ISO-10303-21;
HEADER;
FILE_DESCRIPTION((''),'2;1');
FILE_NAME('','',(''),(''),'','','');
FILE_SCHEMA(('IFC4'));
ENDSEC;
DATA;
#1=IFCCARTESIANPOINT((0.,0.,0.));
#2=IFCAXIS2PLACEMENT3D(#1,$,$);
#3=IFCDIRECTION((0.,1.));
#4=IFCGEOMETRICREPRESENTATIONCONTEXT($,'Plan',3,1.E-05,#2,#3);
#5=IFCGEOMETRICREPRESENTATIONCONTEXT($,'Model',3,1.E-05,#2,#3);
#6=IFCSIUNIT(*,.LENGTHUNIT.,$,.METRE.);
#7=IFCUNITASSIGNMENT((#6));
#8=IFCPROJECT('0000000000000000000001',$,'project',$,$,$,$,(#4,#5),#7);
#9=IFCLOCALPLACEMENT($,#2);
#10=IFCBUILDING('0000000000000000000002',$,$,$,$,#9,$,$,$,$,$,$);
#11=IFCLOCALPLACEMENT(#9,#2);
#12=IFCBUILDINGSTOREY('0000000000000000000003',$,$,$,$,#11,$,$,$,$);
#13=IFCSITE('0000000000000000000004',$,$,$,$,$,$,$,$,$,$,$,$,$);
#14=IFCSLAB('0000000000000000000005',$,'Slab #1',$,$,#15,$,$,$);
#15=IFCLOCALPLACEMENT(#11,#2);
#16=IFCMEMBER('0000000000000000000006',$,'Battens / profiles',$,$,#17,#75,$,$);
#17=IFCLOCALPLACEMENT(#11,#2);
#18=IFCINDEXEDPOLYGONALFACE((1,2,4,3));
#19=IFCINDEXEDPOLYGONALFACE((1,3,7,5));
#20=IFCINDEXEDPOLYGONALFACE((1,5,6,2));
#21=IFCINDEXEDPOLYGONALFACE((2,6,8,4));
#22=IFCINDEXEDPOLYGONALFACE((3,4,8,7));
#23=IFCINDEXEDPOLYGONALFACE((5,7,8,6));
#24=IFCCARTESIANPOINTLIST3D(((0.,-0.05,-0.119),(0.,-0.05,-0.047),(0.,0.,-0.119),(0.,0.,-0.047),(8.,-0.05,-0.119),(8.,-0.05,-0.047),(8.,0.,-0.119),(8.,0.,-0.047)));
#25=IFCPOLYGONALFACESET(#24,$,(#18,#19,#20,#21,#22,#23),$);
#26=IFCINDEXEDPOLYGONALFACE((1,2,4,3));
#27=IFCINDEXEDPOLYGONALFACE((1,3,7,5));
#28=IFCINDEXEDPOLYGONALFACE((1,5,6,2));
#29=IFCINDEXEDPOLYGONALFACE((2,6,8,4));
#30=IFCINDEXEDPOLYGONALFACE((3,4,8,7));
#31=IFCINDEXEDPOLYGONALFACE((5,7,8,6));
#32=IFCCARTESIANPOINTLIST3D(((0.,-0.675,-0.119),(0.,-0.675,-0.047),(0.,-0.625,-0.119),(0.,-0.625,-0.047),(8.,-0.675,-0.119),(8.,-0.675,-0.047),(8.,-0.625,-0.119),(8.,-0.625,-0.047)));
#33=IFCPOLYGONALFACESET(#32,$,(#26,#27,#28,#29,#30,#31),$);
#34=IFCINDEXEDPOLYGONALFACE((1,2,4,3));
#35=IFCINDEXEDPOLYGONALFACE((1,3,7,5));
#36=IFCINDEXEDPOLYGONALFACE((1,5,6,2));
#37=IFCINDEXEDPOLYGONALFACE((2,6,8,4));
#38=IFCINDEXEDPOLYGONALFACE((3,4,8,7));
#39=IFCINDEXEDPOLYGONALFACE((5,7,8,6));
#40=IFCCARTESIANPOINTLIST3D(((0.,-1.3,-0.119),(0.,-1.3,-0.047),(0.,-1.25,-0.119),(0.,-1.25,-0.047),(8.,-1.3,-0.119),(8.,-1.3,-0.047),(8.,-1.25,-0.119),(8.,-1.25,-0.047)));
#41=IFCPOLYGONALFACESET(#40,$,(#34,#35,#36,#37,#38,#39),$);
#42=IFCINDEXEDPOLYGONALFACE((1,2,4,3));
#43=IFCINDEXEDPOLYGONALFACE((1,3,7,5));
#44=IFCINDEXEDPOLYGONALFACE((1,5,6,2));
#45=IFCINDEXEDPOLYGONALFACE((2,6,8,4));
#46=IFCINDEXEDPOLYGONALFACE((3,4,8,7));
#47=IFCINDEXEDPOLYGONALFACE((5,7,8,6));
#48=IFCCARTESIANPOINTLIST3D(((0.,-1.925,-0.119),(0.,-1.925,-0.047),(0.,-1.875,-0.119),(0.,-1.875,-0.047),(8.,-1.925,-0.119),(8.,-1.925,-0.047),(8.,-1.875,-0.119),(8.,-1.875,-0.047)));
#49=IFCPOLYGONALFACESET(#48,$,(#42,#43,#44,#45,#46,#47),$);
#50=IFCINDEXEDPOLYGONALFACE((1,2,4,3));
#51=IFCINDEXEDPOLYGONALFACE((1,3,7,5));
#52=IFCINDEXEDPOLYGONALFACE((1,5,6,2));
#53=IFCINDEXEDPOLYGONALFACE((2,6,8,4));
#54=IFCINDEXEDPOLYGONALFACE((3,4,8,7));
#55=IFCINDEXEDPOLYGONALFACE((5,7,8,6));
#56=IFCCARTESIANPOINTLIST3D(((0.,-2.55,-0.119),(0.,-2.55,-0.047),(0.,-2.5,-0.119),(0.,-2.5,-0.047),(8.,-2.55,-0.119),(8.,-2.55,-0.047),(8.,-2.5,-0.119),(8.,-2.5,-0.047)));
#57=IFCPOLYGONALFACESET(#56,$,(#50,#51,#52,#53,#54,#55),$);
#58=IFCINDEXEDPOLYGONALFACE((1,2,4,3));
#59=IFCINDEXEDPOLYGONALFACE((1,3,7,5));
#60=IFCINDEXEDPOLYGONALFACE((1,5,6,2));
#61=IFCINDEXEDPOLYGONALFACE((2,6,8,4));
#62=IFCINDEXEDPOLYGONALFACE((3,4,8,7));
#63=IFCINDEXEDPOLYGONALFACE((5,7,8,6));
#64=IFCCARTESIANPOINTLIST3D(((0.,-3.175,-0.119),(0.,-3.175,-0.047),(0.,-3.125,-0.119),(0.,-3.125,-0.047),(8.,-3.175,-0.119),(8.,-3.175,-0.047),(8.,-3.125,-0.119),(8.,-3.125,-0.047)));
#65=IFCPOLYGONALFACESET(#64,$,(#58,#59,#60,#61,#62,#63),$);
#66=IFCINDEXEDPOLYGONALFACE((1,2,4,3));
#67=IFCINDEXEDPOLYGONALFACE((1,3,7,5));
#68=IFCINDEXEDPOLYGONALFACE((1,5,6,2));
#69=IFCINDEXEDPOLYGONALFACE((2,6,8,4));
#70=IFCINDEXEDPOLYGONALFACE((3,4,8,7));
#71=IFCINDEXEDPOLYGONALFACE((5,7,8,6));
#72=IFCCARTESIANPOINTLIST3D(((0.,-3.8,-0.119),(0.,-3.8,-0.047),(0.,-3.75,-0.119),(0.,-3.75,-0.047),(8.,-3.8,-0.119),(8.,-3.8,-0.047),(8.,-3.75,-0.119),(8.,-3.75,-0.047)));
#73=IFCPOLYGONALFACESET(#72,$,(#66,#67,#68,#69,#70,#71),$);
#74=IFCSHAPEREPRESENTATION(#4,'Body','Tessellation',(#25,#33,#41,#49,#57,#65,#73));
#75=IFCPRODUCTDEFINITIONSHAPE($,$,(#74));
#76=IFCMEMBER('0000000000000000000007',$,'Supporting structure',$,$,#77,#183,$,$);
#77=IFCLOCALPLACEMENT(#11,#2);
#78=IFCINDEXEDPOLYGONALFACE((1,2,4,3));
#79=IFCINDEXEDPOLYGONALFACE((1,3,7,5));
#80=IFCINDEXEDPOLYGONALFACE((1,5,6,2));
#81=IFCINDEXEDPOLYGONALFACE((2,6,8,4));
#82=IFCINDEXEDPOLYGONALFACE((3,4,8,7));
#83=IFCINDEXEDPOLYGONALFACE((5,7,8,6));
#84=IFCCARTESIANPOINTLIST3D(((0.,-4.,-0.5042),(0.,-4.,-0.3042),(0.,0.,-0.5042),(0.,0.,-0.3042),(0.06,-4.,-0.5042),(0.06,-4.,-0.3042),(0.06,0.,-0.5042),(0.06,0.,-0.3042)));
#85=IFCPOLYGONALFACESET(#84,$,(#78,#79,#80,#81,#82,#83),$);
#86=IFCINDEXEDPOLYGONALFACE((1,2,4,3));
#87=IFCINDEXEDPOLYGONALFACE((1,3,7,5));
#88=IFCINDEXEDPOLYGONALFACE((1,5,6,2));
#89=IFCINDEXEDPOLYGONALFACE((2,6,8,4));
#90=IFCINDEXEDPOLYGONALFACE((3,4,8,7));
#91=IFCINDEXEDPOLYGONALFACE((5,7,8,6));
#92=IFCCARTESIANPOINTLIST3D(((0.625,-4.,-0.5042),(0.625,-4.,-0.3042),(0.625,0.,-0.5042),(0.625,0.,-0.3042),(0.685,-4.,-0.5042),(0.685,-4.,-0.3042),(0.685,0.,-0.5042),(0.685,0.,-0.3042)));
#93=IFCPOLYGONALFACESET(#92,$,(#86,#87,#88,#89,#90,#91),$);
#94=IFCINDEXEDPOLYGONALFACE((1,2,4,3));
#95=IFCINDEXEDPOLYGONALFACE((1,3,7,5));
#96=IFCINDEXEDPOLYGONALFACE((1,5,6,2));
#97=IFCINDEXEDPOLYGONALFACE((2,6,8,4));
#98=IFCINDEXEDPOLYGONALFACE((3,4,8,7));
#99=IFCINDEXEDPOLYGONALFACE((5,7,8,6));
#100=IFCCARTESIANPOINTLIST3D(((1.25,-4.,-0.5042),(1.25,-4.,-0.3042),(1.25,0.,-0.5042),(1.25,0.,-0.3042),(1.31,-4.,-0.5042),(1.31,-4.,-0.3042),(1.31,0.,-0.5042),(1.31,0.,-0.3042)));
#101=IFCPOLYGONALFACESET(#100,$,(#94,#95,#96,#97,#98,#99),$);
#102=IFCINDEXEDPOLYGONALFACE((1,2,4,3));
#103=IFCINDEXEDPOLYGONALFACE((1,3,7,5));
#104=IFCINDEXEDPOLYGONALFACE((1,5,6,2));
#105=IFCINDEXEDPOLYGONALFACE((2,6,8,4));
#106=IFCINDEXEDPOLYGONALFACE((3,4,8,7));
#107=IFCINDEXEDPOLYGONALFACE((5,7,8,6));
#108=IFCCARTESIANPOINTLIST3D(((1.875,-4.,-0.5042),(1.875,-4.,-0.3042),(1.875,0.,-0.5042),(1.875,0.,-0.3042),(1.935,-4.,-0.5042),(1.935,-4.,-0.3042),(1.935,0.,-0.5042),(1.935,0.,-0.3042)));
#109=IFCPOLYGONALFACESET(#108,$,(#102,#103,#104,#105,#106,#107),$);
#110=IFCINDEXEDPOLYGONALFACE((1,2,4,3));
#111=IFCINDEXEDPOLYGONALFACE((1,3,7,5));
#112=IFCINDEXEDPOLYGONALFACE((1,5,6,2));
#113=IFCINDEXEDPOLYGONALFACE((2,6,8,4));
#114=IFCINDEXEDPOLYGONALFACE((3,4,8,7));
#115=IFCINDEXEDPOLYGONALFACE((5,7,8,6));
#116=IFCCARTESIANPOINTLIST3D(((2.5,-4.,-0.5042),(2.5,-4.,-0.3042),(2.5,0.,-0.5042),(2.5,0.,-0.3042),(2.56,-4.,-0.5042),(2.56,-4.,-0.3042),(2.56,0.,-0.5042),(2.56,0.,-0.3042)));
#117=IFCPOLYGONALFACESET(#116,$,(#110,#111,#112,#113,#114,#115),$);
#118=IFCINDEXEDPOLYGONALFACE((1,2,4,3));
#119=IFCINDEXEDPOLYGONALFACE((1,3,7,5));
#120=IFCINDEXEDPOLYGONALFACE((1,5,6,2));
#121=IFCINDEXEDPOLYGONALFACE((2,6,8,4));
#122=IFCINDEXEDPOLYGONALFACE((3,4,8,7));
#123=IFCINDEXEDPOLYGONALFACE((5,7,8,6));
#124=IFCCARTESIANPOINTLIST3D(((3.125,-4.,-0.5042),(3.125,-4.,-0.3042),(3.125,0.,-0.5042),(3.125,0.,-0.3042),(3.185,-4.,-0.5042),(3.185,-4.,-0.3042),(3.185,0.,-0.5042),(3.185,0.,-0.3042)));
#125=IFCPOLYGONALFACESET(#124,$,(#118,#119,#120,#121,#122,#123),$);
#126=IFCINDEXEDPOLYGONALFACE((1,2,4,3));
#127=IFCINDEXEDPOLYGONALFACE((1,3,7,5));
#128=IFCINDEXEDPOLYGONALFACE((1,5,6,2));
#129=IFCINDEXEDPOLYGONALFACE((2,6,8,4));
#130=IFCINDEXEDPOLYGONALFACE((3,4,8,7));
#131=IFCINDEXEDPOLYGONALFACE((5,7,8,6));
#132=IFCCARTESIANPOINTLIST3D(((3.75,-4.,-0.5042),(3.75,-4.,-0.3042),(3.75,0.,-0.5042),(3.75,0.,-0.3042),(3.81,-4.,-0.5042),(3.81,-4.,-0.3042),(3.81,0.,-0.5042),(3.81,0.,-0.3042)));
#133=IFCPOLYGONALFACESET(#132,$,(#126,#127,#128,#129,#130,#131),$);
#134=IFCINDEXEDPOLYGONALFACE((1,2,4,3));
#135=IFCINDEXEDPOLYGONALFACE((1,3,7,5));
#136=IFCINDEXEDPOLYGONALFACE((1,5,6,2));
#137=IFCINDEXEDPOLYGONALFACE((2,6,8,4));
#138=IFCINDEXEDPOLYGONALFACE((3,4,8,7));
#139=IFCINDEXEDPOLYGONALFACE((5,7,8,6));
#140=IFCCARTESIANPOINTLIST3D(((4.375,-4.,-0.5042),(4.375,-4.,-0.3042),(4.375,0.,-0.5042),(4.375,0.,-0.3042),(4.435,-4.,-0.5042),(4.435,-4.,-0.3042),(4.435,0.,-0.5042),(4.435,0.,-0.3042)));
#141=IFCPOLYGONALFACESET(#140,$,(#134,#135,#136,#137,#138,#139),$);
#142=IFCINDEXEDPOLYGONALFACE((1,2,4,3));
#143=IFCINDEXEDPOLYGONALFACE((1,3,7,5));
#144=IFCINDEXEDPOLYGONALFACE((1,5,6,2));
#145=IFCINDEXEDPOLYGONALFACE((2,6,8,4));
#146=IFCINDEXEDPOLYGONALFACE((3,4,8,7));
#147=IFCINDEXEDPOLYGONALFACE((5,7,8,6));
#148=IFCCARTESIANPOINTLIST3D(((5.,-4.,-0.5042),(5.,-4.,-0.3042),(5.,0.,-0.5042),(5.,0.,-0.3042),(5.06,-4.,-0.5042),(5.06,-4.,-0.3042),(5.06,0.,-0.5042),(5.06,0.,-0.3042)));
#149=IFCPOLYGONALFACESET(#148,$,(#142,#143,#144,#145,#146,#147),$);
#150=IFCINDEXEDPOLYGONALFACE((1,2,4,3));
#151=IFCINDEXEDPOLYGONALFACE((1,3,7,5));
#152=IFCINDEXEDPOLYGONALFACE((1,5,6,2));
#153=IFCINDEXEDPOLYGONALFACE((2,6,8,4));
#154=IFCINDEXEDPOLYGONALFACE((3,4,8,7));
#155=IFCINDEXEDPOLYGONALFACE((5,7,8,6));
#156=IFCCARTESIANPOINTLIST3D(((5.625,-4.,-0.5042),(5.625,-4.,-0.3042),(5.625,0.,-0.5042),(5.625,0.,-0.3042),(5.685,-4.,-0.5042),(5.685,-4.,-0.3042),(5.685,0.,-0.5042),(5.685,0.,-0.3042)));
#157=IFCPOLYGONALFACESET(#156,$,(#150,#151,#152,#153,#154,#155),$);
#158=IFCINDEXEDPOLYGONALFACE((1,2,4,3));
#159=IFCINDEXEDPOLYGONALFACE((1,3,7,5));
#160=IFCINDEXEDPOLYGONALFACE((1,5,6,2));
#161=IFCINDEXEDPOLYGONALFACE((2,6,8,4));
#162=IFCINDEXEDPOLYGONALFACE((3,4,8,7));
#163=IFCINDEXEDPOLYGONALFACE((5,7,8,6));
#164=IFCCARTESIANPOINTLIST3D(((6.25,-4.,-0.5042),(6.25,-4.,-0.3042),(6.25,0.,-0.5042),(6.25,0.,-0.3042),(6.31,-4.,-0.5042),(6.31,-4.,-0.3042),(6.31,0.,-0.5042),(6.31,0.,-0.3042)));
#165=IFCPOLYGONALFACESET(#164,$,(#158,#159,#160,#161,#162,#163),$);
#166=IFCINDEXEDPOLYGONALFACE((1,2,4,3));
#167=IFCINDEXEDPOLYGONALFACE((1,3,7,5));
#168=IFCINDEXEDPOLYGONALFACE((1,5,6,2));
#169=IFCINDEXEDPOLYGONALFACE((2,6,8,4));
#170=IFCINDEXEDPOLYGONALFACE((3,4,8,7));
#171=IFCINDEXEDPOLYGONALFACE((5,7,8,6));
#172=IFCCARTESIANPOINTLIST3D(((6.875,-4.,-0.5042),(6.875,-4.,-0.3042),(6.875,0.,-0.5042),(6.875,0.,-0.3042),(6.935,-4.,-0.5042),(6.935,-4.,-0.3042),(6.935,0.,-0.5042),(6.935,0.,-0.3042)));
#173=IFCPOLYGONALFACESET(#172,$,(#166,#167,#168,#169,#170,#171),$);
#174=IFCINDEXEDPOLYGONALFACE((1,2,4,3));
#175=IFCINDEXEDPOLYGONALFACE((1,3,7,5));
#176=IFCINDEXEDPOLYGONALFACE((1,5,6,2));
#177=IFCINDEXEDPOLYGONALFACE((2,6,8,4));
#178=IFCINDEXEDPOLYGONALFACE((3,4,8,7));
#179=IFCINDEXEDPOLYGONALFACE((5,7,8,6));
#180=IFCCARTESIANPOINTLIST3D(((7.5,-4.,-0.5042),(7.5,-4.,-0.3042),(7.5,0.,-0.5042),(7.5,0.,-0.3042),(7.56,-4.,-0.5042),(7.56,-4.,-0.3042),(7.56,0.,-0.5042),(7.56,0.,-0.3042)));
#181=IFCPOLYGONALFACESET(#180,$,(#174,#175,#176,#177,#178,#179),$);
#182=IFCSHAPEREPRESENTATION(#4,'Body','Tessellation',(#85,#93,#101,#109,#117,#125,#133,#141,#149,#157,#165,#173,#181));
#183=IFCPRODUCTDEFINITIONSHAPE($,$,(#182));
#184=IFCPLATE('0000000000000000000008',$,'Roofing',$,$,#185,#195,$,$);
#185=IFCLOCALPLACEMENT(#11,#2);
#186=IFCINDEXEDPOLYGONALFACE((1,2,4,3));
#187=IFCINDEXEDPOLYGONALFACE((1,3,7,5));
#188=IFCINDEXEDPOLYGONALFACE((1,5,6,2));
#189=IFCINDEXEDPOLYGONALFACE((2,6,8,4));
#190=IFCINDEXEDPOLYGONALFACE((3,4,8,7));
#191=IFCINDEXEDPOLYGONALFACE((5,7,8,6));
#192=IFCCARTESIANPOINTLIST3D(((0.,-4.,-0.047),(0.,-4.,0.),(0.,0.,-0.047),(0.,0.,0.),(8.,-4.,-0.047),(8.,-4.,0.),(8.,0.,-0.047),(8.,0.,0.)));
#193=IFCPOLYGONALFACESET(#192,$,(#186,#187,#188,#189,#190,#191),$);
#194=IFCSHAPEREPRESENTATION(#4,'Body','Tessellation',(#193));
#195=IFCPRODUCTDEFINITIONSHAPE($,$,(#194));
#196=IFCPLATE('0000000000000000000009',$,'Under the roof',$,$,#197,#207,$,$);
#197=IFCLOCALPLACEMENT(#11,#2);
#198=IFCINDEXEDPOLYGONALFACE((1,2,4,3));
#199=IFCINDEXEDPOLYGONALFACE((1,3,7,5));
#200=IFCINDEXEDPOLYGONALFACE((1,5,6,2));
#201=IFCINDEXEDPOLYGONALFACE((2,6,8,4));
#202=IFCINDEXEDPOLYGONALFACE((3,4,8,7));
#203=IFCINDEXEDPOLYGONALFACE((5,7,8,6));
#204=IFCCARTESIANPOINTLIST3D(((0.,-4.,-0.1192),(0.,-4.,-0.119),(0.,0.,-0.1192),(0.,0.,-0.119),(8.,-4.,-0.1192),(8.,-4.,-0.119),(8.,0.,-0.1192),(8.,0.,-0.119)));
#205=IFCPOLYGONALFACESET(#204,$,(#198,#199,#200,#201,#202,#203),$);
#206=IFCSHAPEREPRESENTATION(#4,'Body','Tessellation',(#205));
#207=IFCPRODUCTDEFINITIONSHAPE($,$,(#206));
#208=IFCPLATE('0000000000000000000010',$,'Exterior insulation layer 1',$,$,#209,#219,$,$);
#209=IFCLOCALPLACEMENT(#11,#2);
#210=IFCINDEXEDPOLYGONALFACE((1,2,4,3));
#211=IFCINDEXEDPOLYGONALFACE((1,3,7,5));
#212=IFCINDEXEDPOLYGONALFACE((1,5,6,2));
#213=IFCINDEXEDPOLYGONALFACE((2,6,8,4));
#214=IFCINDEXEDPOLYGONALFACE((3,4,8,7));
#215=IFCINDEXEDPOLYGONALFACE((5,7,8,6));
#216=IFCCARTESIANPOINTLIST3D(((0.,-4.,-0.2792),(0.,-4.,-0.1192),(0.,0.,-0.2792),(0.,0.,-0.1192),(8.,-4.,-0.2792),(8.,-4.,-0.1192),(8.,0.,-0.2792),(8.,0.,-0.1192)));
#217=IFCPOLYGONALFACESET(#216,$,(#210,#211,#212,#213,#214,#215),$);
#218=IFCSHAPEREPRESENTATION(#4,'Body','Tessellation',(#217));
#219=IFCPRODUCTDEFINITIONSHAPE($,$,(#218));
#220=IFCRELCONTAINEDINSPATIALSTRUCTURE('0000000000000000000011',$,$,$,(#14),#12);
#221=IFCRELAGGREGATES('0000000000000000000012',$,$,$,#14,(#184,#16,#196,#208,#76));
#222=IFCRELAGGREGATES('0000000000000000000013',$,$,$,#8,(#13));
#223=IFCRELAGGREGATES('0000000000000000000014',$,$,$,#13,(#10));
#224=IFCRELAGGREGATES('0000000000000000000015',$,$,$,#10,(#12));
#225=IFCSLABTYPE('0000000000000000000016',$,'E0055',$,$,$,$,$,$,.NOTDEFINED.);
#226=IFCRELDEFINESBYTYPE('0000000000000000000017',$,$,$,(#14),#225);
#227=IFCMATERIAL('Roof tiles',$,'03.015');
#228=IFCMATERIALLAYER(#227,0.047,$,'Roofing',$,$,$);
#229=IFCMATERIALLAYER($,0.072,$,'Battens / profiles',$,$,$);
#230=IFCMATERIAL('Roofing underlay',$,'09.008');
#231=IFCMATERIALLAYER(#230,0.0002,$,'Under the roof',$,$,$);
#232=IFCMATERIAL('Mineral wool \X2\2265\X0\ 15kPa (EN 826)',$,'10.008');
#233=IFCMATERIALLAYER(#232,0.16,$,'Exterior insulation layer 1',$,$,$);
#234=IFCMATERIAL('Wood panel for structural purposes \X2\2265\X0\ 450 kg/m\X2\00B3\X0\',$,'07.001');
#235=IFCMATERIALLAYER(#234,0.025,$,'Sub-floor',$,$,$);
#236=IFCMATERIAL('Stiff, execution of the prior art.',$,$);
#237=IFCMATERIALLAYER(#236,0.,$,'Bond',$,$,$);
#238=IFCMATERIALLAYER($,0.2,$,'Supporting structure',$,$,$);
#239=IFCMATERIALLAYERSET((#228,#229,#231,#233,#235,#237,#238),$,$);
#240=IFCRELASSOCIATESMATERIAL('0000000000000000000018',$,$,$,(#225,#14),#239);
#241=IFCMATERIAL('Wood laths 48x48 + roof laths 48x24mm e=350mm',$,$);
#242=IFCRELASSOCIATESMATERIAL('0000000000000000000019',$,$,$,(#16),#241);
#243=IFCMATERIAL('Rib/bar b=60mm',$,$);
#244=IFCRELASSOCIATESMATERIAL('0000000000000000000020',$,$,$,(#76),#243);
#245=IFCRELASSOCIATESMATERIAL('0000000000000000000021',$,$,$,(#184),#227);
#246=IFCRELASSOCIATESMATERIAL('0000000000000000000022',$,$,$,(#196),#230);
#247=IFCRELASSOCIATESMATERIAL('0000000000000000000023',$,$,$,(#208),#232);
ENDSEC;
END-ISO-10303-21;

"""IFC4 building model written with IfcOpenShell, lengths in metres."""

from ifc_helpers import new_model, si_unit, direction, frame, frame_2d, origin, origin_with_axes, place, context, project, spatial, rectangle, extrude, material, layer, layer_set, type_object, element, aggregate, save


model = new_model("IFC4")

# Units and contexts
plan_context = context("Plan", 3, precision=1e-05, world=origin(), true_north=direction((0.0, 1.0)))
model_context = context("Model", 3, precision=1e-05, world=origin(), true_north=direction((0.0, 1.0)))
ifc_project = project(units=[si_unit("LENGTHUNIT", "METRE")], contexts=[plan_context, model_context])

# Site, building, storey
site = spatial("IfcSite", under=ifc_project)
building_placement = place(None, origin())
building = spatial("IfcBuilding", under=site, at=building_placement)
storey_placement = place(building_placement, origin())
storey = spatial("IfcBuildingStorey", under=building, at=storey_placement)

# Slab, members, plates
ifc_material_1 = material(Name="Roof tiles", Category="03.015")
ifc_layer_1 = layer(ifc_material_1, 0.047, Name="Roofing")
ifc_layer_2 = layer(None, 0.072, Name="Battens / profiles")
ifc_material_2 = material(Name="Roofing underlay", Category="09.008")
ifc_layer_3 = layer(ifc_material_2, 0.0002, Name="Under the roof")
ifc_material_3 = material(Name="Mineral wool ≥ 15kPa (EN 826)", Category="10.008")
ifc_layer_4 = layer(ifc_material_3, 0.16, Name="Exterior insulation layer 1")
ifc_material_4 = material(Name="Wood panel for structural purposes ≥ 450 kg/m³", Category="07.001")
ifc_layer_5 = layer(ifc_material_4, 0.025, Name="Sub-floor")
ifc_material_5 = material(Name="Stiff, execution of the prior art.")
ifc_layer_6 = layer(ifc_material_5, 0.0, Name="Bond")
ifc_layer_7 = layer(None, 0.2, Name="Supporting structure")
ifc_layer_set = layer_set([ifc_layer_1, ifc_layer_2, ifc_layer_3, ifc_layer_4, ifc_layer_5, ifc_layer_6, ifc_layer_7])
slab_type = type_object("IfcSlabType", Name="E0055", PredefinedType="NOTDEFINED", material=ifc_layer_set)
slab_placement = place(None, frame((0.0, 0.0, 0.0), z_axis=(0.0, 0.0, -1.0), x_axis=(1.0, 0.0, 0.0)))
slab = element("IfcSlab", 1, at=slab_placement, inside=storey, type_object=slab_type, material=ifc_layer_set, Name="Slab #1")
ifc_material_6 = material(Name="Wood laths 48x48 + roof laths 48x24mm e=350mm")
member_1_placement = place(slab_placement, origin())
member_1 = element("IfcMember", 2, at=member_1_placement, material=ifc_material_6, Name="Battens / profiles", context=plan_context, shape_type="SweptSolid", body=[
    extrude(rectangle(XDim=0.05, YDim=0.072, at=frame_2d((0.025, 0.036), x_axis=(1.0, 0.0))), frame((0.0, 0.0, 0.047), z_axis=(1.0, 0.0, 0.0), x_axis=(0.0, 1.0, 0.0)), (0.0, 0.0, 1.0), 8.0),
    extrude(rectangle(XDim=0.05, YDim=0.072, at=frame_2d((0.025, 0.036), x_axis=(1.0, 0.0))), frame((0.0, 0.625, 0.047), z_axis=(1.0, 0.0, 0.0), x_axis=(0.0, 1.0, 0.0)), (0.0, 0.0, 1.0), 8.0),
    extrude(rectangle(XDim=0.05, YDim=0.072, at=frame_2d((0.025, 0.036), x_axis=(1.0, 0.0))), frame((0.0, 1.25, 0.047), z_axis=(1.0, 0.0, 0.0), x_axis=(0.0, 1.0, 0.0)), (0.0, 0.0, 1.0), 8.0),
    extrude(rectangle(XDim=0.05, YDim=0.072, at=frame_2d((0.025, 0.036), x_axis=(1.0, 0.0))), frame((0.0, 1.875, 0.047), z_axis=(1.0, 0.0, 0.0), x_axis=(0.0, 1.0, 0.0)), (0.0, 0.0, 1.0), 8.0),
    extrude(rectangle(XDim=0.05, YDim=0.072, at=frame_2d((0.025, 0.036), x_axis=(1.0, 0.0))), frame((0.0, 2.5, 0.047), z_axis=(1.0, 0.0, 0.0), x_axis=(0.0, 1.0, 0.0)), (0.0, 0.0, 1.0), 8.0),
    extrude(rectangle(XDim=0.05, YDim=0.072, at=frame_2d((0.025, 0.036), x_axis=(1.0, 0.0))), frame((0.0, 3.125, 0.047), z_axis=(1.0, 0.0, 0.0), x_axis=(0.0, 1.0, 0.0)), (0.0, 0.0, 1.0), 8.0),
    extrude(rectangle(XDim=0.05, YDim=0.072, at=frame_2d((0.025, 0.036), x_axis=(1.0, 0.0))), frame((0.0, 3.75, 0.047), z_axis=(1.0, 0.0, 0.0), x_axis=(0.0, 1.0, 0.0)), (0.0, 0.0, 1.0), 8.0),
])
ifc_material_7 = material(Name="Rib/bar b=60mm")
member_2_placement = place(slab_placement, origin())
member_2 = element("IfcMember", 3, at=member_2_placement, material=ifc_material_7, Name="Supporting structure", context=plan_context, shape_type="SweptSolid", body=[
    extrude(rectangle(XDim=0.06, YDim=0.2, at=frame_2d((0.03, 0.1), x_axis=(1.0, 0.0))), frame((0.0, 4.0, 0.3042), z_axis=(0.0, -1.0, 0.0), x_axis=(1.0, 0.0, 0.0)), (0.0, 0.0, 1.0), 4.0),
    extrude(rectangle(XDim=0.06, YDim=0.2, at=frame_2d((0.03, 0.1), x_axis=(1.0, 0.0))), frame((0.625, 4.0, 0.3042), z_axis=(0.0, -1.0, 0.0), x_axis=(1.0, 0.0, 0.0)), (0.0, 0.0, 1.0), 4.0),
    extrude(rectangle(XDim=0.06, YDim=0.2, at=frame_2d((0.03, 0.1), x_axis=(1.0, 0.0))), frame((1.25, 4.0, 0.3042), z_axis=(0.0, -1.0, 0.0), x_axis=(1.0, 0.0, 0.0)), (0.0, 0.0, 1.0), 4.0),
    extrude(rectangle(XDim=0.06, YDim=0.2, at=frame_2d((0.03, 0.1), x_axis=(1.0, 0.0))), frame((1.875, 4.0, 0.3042), z_axis=(0.0, -1.0, 0.0), x_axis=(1.0, 0.0, 0.0)), (0.0, 0.0, 1.0), 4.0),
    extrude(rectangle(XDim=0.06, YDim=0.2, at=frame_2d((0.03, 0.1), x_axis=(1.0, 0.0))), frame((2.5, 4.0, 0.3042), z_axis=(0.0, -1.0, 0.0), x_axis=(1.0, 0.0, 0.0)), (0.0, 0.0, 1.0), 4.0),
    extrude(rectangle(XDim=0.06, YDim=0.2, at=frame_2d((0.03, 0.1), x_axis=(1.0, 0.0))), frame((3.125, 4.0, 0.3042), z_axis=(0.0, -1.0, 0.0), x_axis=(1.0, 0.0, 0.0)), (0.0, 0.0, 1.0), 4.0),
    extrude(rectangle(XDim=0.06, YDim=0.2, at=frame_2d((0.03, 0.1), x_axis=(1.0, 0.0))), frame((3.75, 4.0, 0.3042), z_axis=(0.0, -1.0, 0.0), x_axis=(1.0, 0.0, 0.0)), (0.0, 0.0, 1.0), 4.0),
    extrude(rectangle(XDim=0.06, YDim=0.2, at=frame_2d((0.03, 0.1), x_axis=(1.0, 0.0))), frame((4.375, 4.0, 0.3042), z_axis=(0.0, -1.0, 0.0), x_axis=(1.0, 0.0, 0.0)), (0.0, 0.0, 1.0), 4.0),
    extrude(rectangle(XDim=0.06, YDim=0.2, at=frame_2d((0.03, 0.1), x_axis=(1.0, 0.0))), frame((5.0, 4.0, 0.3042), z_axis=(0.0, -1.0, 0.0), x_axis=(1.0, 0.0, 0.0)), (0.0, 0.0, 1.0), 4.0),
    extrude(rectangle(XDim=0.06, YDim=0.2, at=frame_2d((0.03, 0.1), x_axis=(1.0, 0.0))), frame((5.625, 4.0, 0.3042), z_axis=(0.0, -1.0, 0.0), x_axis=(1.0, 0.0, 0.0)), (0.0, 0.0, 1.0), 4.0),
    extrude(rectangle(XDim=0.06, YDim=0.2, at=frame_2d((0.03, 0.1), x_axis=(1.0, 0.0))), frame((6.25, 4.0, 0.3042), z_axis=(0.0, -1.0, 0.0), x_axis=(1.0, 0.0, 0.0)), (0.0, 0.0, 1.0), 4.0),
    extrude(rectangle(XDim=0.06, YDim=0.2, at=frame_2d((0.03, 0.1), x_axis=(1.0, 0.0))), frame((6.875, 4.0, 0.3042), z_axis=(0.0, -1.0, 0.0), x_axis=(1.0, 0.0, 0.0)), (0.0, 0.0, 1.0), 4.0),
    extrude(rectangle(XDim=0.06, YDim=0.2, at=frame_2d((0.03, 0.1), x_axis=(1.0, 0.0))), frame((7.5, 4.0, 0.3042), z_axis=(0.0, -1.0, 0.0), x_axis=(1.0, 0.0, 0.0)), (0.0, 0.0, 1.0), 4.0),
])
plate_1_placement = place(slab_placement, origin())
plate_1 = element("IfcPlate", 4, at=plate_1_placement, material=ifc_material_1, Name="Roofing", context=plan_context, shape_type="SweptSolid", body=[
    extrude(rectangle(XDim=8.0, YDim=4.0, at=frame_2d((4.0, 2.0), x_axis=(1.0, 0.0))), origin_with_axes(), (0.0, 0.0, 1.0), 0.047),
])
plate_2_placement = place(slab_placement, origin())
plate_2 = element("IfcPlate", 5, at=plate_2_placement, material=ifc_material_2, Name="Under the roof", context=plan_context, shape_type="SweptSolid", body=[
    extrude(rectangle(XDim=8.0, YDim=4.0, at=frame_2d((4.0, 2.0), x_axis=(1.0, 0.0))), frame((0.0, 0.0, 0.119), z_axis=(0.0, 0.0, 1.0), x_axis=(1.0, 0.0, 0.0)), (0.0, 0.0, 1.0), 0.0002),
])
plate_3_placement = place(slab_placement, origin())
plate_3 = element("IfcPlate", 6, at=plate_3_placement, material=ifc_material_3, Name="Exterior insulation layer 1", context=plan_context, shape_type="SweptSolid", body=[
    extrude(rectangle(XDim=8.0, YDim=4.0, at=frame_2d((4.0, 2.0), x_axis=(1.0, 0.0))), frame((0.0, 0.0, 0.1192), z_axis=(0.0, 0.0, 1.0), x_axis=(1.0, 0.0, 0.0)), (0.0, 0.0, 1.0), 0.16),
])
aggregate(slab, [plate_1, member_1, plate_2, plate_3, member_2])

save(model, "model.ifc")
